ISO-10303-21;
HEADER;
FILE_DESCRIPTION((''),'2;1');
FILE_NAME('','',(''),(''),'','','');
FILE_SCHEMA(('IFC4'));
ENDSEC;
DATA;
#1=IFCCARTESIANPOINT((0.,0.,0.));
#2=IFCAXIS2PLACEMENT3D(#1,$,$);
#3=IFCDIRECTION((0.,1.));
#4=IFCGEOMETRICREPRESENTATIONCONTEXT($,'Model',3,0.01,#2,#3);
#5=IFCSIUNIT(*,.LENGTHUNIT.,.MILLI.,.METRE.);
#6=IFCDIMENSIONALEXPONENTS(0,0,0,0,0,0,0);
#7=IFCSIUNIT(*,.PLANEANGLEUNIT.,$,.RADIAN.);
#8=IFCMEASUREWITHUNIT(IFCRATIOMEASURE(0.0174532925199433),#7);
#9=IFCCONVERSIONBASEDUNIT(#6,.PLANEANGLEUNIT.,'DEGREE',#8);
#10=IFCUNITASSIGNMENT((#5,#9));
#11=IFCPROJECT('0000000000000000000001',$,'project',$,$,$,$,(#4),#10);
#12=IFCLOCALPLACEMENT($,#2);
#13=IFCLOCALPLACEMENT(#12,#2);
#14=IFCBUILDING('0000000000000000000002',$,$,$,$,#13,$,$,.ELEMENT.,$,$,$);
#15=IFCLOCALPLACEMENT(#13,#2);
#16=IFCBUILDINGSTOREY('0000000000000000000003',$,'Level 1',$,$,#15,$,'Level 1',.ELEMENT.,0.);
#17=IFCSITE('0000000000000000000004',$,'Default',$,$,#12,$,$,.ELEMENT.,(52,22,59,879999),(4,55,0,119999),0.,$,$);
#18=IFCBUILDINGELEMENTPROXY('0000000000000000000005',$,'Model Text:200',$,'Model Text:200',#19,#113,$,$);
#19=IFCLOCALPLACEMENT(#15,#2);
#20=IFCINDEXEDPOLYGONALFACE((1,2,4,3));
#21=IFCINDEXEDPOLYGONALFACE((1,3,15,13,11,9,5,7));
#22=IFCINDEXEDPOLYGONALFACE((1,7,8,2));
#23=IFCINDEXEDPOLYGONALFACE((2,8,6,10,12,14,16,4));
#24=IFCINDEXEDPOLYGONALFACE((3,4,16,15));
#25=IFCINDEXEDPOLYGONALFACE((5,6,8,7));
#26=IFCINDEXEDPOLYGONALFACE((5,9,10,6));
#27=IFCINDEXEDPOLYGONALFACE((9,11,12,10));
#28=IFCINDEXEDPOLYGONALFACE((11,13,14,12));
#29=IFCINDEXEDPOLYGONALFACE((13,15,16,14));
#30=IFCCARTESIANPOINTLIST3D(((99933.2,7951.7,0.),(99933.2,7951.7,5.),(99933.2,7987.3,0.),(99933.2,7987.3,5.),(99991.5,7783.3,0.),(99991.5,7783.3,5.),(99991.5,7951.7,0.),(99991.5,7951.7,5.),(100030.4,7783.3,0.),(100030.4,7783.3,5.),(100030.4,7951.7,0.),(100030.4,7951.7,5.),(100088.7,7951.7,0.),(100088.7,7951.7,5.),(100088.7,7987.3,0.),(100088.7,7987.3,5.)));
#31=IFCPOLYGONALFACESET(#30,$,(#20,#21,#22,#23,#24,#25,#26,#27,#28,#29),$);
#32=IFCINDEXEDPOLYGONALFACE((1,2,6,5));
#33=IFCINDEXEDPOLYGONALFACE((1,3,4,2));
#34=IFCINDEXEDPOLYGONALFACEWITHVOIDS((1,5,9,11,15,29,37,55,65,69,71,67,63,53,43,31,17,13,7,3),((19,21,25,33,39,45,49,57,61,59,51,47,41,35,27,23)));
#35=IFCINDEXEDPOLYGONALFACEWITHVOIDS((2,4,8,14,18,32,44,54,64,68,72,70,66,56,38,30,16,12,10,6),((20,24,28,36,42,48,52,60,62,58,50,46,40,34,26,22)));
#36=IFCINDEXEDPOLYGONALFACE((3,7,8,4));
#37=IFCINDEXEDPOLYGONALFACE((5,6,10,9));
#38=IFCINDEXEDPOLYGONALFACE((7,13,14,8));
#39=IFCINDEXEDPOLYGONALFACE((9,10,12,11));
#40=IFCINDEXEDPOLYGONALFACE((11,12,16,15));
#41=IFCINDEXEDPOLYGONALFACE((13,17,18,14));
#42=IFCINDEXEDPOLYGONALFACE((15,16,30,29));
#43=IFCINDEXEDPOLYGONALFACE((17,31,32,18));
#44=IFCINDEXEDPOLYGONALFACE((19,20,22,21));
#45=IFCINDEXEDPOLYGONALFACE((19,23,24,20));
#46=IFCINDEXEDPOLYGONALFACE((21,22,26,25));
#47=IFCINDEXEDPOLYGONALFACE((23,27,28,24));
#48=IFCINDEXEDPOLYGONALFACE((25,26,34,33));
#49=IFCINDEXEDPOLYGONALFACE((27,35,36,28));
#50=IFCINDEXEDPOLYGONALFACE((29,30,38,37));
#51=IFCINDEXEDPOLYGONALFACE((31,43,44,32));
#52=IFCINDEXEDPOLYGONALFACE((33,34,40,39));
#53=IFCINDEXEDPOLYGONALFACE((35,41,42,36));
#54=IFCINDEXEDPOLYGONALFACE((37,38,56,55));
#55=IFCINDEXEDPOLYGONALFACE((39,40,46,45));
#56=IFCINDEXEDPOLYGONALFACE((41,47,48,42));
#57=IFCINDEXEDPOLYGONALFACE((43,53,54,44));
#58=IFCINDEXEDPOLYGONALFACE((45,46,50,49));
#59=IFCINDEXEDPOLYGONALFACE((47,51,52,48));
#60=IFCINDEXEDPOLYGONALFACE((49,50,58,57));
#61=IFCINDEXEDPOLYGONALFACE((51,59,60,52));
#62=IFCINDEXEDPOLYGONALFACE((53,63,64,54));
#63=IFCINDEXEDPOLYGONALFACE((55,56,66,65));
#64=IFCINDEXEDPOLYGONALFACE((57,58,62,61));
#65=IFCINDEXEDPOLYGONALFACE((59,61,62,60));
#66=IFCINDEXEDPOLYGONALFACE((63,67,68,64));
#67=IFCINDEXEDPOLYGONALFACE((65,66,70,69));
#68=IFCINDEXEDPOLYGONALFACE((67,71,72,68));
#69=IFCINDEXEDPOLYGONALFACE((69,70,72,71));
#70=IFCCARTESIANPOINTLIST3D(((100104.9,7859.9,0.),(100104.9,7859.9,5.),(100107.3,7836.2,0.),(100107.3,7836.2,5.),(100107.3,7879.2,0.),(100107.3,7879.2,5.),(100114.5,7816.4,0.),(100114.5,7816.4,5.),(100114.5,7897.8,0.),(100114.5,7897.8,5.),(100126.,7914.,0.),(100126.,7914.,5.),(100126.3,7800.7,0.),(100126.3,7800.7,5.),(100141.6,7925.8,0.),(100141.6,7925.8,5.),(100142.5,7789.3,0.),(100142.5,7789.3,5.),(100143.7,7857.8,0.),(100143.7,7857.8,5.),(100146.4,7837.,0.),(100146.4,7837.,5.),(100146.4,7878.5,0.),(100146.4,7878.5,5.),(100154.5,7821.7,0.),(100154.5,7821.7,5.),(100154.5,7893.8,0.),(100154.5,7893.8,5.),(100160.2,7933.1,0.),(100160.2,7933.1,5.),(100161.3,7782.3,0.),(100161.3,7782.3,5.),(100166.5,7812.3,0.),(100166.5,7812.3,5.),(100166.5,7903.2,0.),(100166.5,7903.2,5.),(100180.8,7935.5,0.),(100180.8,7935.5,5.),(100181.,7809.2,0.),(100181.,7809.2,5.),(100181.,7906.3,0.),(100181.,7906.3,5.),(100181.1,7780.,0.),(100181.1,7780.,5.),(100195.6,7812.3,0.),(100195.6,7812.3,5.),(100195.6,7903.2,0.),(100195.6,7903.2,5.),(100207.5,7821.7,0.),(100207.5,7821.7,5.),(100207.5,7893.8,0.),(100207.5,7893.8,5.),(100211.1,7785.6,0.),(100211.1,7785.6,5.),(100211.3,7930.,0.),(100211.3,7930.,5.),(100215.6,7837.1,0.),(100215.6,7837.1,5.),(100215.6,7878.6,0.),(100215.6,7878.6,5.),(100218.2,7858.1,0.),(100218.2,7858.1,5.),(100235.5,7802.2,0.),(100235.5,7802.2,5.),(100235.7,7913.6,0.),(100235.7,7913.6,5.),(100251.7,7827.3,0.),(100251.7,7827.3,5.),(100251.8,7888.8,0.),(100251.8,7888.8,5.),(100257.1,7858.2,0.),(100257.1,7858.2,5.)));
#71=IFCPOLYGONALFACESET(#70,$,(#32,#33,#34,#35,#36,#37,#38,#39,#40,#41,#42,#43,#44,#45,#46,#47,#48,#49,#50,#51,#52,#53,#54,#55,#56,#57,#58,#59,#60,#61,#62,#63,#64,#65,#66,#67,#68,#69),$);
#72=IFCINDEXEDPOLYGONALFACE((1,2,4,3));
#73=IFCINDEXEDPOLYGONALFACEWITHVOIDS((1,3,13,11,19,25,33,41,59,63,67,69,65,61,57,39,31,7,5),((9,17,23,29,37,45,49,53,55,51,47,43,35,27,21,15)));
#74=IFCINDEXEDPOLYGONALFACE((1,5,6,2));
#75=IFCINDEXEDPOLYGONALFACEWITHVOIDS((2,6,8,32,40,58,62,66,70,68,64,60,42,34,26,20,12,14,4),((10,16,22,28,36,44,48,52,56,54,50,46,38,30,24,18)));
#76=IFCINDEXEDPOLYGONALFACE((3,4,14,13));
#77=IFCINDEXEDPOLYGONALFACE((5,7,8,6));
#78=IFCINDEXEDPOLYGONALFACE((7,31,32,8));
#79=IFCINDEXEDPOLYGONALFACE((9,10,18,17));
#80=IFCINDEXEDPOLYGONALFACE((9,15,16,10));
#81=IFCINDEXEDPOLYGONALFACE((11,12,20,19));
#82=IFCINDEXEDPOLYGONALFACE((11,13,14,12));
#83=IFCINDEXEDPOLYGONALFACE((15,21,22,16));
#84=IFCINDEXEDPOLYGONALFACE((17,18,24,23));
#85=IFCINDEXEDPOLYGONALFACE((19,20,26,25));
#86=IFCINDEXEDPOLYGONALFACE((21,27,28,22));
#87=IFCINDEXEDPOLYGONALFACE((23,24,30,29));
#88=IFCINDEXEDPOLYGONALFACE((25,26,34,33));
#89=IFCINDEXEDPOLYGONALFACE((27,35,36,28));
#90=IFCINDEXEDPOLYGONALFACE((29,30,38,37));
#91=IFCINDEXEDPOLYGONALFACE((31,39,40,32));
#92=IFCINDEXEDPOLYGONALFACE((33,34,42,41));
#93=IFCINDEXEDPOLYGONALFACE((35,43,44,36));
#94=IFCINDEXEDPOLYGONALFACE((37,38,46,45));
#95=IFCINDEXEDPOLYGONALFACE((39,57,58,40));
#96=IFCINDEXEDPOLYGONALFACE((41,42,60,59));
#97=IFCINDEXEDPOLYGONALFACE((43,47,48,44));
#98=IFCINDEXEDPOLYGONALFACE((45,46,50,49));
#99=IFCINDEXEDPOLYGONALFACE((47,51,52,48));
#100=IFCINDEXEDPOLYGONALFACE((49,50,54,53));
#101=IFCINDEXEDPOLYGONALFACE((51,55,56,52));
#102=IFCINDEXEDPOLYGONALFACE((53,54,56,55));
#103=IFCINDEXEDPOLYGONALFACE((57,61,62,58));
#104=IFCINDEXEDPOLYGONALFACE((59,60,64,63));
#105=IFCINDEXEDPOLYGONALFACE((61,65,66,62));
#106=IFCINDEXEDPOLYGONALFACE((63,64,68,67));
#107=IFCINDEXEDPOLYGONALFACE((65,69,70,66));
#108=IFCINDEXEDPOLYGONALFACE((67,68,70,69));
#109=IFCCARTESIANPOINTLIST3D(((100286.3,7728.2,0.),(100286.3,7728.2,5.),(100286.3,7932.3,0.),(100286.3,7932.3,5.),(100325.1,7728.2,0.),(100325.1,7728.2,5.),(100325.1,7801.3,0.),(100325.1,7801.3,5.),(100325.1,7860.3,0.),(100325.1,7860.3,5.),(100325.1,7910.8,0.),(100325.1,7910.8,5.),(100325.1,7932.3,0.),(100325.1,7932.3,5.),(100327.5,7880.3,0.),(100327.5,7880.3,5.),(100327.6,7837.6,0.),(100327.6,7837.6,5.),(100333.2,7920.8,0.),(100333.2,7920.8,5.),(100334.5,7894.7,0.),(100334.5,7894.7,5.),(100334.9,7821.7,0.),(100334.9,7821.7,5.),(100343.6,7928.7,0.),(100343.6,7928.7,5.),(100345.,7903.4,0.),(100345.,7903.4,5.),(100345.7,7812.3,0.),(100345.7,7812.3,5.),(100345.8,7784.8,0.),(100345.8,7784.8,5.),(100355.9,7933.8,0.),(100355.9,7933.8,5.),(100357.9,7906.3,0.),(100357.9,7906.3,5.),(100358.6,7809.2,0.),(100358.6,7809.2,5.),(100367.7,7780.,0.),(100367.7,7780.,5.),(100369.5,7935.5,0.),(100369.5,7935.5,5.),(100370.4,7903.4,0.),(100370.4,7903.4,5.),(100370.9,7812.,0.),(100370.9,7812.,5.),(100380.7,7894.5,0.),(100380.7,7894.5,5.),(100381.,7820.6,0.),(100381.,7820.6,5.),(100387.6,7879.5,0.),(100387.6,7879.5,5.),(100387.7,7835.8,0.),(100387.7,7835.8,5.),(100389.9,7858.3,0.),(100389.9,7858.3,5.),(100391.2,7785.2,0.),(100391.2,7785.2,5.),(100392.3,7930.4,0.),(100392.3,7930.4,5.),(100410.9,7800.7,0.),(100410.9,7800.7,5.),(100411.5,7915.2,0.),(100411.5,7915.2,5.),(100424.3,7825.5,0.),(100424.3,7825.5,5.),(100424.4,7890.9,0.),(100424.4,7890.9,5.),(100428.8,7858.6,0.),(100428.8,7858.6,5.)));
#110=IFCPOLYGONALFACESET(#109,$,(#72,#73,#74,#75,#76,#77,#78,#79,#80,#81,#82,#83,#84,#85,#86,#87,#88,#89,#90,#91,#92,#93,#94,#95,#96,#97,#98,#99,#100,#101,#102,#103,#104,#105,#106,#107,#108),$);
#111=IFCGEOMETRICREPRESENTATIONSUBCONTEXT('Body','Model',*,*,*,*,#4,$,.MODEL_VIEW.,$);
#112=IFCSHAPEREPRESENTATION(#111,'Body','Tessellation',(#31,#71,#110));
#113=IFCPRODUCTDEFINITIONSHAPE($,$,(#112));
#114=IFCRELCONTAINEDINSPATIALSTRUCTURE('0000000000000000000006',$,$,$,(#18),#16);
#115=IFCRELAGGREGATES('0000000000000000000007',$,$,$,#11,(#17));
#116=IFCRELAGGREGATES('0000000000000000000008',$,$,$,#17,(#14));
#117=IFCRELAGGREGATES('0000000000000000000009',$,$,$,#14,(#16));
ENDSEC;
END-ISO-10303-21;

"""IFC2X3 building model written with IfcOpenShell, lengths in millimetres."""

from ifc_helpers import new_model, entity, si_unit, converted_unit, direction, frame, origin, place, context, subcontext, project, spatial, polyline, outline, extrude, element, save


model = new_model("IFC2X3")

# Units and contexts
model_context = context("Model", 3, precision=0.01, world=origin(), true_north=direction((0.0, 1.0)))
body_context = subcontext(model_context, "Body", "Model", "MODEL_VIEW")
ifc_project = project(units=[si_unit("LENGTHUNIT", "METRE", prefix="MILLI"), converted_unit("PLANEANGLEUNIT", "DEGREE", entity("IfcRatioMeasure", 0.0174532925199433), si_unit("PLANEANGLEUNIT", "RADIAN"), dimensions=[0, 0, 0, 0, 0, 0, 0])], contexts=[model_context])

# Site, building, storey
site_placement = place(None, origin())
site = spatial("IfcSite", under=ifc_project, at=site_placement, Name="Default", CompositionType="ELEMENT", RefLatitude=(52, 22, 59, 879999), RefLongitude=(4, 55, 0, 119999), RefElevation=0.0)
building_placement = place(site_placement, origin())
building = spatial("IfcBuilding", under=site, at=building_placement, CompositionType="ELEMENT")
storey_placement = place(building_placement, origin())
storey = spatial("IfcBuildingStorey", under=building, at=storey_placement, Name="Level 1", LongName="Level 1", CompositionType="ELEMENT", Elevation=0.0)

# Building element proxy
proxy_1_placement = place(building_placement, origin())
element("IfcBuildingElementProxy", 1, at=proxy_1_placement, inside=storey, Name="Model Text:200", ObjectType="Model Text:200", context=body_context, shape_type="SweptSolid", body=[
    extrude(outline(polyline([(-19.4, -135.2), (19.4, -135.2), (19.4, 33.2), (77.7, 33.2), (77.7, 68.8), (-77.7, 68.8), (-77.7, 33.2), (-19.4, 33.2), (-19.4, -135.2)])), frame((100010.9, 7918.5, 0.0)), (0.0, 0.0, 1.0), 5.0),
    extrude(outline(polyline([(-8.8, -65.7), (15.1, -65.7), (35.5, -60.5), (52.3, -50.4), (65.3, -35.4), (74.1, -17.3), (78.4, 2.1), (75.9, 32.5), (61.8, 58.5), (38.4, 77.1), (8.3, 85.6), (-22.7, 83.3), (-49.0, 69.9), (-67.8, 47.3), (-76.3, 17.5), (-76.0, -3.3), (-70.7, -22.5), (-60.5, -39.2), (-45.5, -52.3), (-27.7, -61.4), (-8.8, -65.7)]), holes=[polyline([(-2.7, -27.2), (-23.1, -22.5), (-37.5, -12.9), (-45.7, 0.0), (-47.3, 14.8), (-42.7, 28.9), (-32.2, 39.9), (-16.3, 46.3), (4.5, 46.9), (25.1, 42.1), (39.6, 32.6), (47.7, 19.7), (49.4, 5.0), (44.8, -9.2), (34.2, -20.2), (18.2, -26.7), (-2.7, -27.2)])]), frame((100171.1, 7857.8, 0.0), z_axis=(0.0, 0.0, 1.0), x_axis=(0.100608, -0.994926, 0.0)), (0.0, 0.0, 1.0), 5.0),
    extrude(outline(polyline([(-73.1, -75.4), (130.9, -75.4), (130.9, -36.6), (57.8, -36.6), (74.3, -15.9), (79.1, 6.0), (73.9, 29.5), (58.4, 49.2), (33.6, 62.6), (0.5, 67.1), (-31.8, 62.8), (-56.1, 49.8), (-71.3, 30.7), (-76.4, 7.8), (-74.7, -5.8), (-69.6, -18.1), (-61.7, -28.5), (-51.7, -36.6), (-73.1, -36.6), (-73.1, -75.4)]), holes=[polyline([(-1.2, -36.6), (-21.2, -34.2), (-35.6, -27.2), (-44.3, -16.7), (-47.2, -3.8), (-44.3, 8.7), (-35.4, 19.0), (-20.4, 25.9), (0.8, 28.2), (23.3, 26.0), (38.5, 19.3), (47.1, 9.2), (49.9, -3.1), (46.8, -16.0), (37.4, -26.8), (21.5, -34.1), (-1.2, -36.6)])]), frame((100361.7, 7859.1, 0.0), z_axis=(0.0, 0.0, 1.0), x_axis=(0.0, -1.0, 0.0)), (0.0, 0.0, 1.0), 5.0),
])

save(model, "model.ifc")
